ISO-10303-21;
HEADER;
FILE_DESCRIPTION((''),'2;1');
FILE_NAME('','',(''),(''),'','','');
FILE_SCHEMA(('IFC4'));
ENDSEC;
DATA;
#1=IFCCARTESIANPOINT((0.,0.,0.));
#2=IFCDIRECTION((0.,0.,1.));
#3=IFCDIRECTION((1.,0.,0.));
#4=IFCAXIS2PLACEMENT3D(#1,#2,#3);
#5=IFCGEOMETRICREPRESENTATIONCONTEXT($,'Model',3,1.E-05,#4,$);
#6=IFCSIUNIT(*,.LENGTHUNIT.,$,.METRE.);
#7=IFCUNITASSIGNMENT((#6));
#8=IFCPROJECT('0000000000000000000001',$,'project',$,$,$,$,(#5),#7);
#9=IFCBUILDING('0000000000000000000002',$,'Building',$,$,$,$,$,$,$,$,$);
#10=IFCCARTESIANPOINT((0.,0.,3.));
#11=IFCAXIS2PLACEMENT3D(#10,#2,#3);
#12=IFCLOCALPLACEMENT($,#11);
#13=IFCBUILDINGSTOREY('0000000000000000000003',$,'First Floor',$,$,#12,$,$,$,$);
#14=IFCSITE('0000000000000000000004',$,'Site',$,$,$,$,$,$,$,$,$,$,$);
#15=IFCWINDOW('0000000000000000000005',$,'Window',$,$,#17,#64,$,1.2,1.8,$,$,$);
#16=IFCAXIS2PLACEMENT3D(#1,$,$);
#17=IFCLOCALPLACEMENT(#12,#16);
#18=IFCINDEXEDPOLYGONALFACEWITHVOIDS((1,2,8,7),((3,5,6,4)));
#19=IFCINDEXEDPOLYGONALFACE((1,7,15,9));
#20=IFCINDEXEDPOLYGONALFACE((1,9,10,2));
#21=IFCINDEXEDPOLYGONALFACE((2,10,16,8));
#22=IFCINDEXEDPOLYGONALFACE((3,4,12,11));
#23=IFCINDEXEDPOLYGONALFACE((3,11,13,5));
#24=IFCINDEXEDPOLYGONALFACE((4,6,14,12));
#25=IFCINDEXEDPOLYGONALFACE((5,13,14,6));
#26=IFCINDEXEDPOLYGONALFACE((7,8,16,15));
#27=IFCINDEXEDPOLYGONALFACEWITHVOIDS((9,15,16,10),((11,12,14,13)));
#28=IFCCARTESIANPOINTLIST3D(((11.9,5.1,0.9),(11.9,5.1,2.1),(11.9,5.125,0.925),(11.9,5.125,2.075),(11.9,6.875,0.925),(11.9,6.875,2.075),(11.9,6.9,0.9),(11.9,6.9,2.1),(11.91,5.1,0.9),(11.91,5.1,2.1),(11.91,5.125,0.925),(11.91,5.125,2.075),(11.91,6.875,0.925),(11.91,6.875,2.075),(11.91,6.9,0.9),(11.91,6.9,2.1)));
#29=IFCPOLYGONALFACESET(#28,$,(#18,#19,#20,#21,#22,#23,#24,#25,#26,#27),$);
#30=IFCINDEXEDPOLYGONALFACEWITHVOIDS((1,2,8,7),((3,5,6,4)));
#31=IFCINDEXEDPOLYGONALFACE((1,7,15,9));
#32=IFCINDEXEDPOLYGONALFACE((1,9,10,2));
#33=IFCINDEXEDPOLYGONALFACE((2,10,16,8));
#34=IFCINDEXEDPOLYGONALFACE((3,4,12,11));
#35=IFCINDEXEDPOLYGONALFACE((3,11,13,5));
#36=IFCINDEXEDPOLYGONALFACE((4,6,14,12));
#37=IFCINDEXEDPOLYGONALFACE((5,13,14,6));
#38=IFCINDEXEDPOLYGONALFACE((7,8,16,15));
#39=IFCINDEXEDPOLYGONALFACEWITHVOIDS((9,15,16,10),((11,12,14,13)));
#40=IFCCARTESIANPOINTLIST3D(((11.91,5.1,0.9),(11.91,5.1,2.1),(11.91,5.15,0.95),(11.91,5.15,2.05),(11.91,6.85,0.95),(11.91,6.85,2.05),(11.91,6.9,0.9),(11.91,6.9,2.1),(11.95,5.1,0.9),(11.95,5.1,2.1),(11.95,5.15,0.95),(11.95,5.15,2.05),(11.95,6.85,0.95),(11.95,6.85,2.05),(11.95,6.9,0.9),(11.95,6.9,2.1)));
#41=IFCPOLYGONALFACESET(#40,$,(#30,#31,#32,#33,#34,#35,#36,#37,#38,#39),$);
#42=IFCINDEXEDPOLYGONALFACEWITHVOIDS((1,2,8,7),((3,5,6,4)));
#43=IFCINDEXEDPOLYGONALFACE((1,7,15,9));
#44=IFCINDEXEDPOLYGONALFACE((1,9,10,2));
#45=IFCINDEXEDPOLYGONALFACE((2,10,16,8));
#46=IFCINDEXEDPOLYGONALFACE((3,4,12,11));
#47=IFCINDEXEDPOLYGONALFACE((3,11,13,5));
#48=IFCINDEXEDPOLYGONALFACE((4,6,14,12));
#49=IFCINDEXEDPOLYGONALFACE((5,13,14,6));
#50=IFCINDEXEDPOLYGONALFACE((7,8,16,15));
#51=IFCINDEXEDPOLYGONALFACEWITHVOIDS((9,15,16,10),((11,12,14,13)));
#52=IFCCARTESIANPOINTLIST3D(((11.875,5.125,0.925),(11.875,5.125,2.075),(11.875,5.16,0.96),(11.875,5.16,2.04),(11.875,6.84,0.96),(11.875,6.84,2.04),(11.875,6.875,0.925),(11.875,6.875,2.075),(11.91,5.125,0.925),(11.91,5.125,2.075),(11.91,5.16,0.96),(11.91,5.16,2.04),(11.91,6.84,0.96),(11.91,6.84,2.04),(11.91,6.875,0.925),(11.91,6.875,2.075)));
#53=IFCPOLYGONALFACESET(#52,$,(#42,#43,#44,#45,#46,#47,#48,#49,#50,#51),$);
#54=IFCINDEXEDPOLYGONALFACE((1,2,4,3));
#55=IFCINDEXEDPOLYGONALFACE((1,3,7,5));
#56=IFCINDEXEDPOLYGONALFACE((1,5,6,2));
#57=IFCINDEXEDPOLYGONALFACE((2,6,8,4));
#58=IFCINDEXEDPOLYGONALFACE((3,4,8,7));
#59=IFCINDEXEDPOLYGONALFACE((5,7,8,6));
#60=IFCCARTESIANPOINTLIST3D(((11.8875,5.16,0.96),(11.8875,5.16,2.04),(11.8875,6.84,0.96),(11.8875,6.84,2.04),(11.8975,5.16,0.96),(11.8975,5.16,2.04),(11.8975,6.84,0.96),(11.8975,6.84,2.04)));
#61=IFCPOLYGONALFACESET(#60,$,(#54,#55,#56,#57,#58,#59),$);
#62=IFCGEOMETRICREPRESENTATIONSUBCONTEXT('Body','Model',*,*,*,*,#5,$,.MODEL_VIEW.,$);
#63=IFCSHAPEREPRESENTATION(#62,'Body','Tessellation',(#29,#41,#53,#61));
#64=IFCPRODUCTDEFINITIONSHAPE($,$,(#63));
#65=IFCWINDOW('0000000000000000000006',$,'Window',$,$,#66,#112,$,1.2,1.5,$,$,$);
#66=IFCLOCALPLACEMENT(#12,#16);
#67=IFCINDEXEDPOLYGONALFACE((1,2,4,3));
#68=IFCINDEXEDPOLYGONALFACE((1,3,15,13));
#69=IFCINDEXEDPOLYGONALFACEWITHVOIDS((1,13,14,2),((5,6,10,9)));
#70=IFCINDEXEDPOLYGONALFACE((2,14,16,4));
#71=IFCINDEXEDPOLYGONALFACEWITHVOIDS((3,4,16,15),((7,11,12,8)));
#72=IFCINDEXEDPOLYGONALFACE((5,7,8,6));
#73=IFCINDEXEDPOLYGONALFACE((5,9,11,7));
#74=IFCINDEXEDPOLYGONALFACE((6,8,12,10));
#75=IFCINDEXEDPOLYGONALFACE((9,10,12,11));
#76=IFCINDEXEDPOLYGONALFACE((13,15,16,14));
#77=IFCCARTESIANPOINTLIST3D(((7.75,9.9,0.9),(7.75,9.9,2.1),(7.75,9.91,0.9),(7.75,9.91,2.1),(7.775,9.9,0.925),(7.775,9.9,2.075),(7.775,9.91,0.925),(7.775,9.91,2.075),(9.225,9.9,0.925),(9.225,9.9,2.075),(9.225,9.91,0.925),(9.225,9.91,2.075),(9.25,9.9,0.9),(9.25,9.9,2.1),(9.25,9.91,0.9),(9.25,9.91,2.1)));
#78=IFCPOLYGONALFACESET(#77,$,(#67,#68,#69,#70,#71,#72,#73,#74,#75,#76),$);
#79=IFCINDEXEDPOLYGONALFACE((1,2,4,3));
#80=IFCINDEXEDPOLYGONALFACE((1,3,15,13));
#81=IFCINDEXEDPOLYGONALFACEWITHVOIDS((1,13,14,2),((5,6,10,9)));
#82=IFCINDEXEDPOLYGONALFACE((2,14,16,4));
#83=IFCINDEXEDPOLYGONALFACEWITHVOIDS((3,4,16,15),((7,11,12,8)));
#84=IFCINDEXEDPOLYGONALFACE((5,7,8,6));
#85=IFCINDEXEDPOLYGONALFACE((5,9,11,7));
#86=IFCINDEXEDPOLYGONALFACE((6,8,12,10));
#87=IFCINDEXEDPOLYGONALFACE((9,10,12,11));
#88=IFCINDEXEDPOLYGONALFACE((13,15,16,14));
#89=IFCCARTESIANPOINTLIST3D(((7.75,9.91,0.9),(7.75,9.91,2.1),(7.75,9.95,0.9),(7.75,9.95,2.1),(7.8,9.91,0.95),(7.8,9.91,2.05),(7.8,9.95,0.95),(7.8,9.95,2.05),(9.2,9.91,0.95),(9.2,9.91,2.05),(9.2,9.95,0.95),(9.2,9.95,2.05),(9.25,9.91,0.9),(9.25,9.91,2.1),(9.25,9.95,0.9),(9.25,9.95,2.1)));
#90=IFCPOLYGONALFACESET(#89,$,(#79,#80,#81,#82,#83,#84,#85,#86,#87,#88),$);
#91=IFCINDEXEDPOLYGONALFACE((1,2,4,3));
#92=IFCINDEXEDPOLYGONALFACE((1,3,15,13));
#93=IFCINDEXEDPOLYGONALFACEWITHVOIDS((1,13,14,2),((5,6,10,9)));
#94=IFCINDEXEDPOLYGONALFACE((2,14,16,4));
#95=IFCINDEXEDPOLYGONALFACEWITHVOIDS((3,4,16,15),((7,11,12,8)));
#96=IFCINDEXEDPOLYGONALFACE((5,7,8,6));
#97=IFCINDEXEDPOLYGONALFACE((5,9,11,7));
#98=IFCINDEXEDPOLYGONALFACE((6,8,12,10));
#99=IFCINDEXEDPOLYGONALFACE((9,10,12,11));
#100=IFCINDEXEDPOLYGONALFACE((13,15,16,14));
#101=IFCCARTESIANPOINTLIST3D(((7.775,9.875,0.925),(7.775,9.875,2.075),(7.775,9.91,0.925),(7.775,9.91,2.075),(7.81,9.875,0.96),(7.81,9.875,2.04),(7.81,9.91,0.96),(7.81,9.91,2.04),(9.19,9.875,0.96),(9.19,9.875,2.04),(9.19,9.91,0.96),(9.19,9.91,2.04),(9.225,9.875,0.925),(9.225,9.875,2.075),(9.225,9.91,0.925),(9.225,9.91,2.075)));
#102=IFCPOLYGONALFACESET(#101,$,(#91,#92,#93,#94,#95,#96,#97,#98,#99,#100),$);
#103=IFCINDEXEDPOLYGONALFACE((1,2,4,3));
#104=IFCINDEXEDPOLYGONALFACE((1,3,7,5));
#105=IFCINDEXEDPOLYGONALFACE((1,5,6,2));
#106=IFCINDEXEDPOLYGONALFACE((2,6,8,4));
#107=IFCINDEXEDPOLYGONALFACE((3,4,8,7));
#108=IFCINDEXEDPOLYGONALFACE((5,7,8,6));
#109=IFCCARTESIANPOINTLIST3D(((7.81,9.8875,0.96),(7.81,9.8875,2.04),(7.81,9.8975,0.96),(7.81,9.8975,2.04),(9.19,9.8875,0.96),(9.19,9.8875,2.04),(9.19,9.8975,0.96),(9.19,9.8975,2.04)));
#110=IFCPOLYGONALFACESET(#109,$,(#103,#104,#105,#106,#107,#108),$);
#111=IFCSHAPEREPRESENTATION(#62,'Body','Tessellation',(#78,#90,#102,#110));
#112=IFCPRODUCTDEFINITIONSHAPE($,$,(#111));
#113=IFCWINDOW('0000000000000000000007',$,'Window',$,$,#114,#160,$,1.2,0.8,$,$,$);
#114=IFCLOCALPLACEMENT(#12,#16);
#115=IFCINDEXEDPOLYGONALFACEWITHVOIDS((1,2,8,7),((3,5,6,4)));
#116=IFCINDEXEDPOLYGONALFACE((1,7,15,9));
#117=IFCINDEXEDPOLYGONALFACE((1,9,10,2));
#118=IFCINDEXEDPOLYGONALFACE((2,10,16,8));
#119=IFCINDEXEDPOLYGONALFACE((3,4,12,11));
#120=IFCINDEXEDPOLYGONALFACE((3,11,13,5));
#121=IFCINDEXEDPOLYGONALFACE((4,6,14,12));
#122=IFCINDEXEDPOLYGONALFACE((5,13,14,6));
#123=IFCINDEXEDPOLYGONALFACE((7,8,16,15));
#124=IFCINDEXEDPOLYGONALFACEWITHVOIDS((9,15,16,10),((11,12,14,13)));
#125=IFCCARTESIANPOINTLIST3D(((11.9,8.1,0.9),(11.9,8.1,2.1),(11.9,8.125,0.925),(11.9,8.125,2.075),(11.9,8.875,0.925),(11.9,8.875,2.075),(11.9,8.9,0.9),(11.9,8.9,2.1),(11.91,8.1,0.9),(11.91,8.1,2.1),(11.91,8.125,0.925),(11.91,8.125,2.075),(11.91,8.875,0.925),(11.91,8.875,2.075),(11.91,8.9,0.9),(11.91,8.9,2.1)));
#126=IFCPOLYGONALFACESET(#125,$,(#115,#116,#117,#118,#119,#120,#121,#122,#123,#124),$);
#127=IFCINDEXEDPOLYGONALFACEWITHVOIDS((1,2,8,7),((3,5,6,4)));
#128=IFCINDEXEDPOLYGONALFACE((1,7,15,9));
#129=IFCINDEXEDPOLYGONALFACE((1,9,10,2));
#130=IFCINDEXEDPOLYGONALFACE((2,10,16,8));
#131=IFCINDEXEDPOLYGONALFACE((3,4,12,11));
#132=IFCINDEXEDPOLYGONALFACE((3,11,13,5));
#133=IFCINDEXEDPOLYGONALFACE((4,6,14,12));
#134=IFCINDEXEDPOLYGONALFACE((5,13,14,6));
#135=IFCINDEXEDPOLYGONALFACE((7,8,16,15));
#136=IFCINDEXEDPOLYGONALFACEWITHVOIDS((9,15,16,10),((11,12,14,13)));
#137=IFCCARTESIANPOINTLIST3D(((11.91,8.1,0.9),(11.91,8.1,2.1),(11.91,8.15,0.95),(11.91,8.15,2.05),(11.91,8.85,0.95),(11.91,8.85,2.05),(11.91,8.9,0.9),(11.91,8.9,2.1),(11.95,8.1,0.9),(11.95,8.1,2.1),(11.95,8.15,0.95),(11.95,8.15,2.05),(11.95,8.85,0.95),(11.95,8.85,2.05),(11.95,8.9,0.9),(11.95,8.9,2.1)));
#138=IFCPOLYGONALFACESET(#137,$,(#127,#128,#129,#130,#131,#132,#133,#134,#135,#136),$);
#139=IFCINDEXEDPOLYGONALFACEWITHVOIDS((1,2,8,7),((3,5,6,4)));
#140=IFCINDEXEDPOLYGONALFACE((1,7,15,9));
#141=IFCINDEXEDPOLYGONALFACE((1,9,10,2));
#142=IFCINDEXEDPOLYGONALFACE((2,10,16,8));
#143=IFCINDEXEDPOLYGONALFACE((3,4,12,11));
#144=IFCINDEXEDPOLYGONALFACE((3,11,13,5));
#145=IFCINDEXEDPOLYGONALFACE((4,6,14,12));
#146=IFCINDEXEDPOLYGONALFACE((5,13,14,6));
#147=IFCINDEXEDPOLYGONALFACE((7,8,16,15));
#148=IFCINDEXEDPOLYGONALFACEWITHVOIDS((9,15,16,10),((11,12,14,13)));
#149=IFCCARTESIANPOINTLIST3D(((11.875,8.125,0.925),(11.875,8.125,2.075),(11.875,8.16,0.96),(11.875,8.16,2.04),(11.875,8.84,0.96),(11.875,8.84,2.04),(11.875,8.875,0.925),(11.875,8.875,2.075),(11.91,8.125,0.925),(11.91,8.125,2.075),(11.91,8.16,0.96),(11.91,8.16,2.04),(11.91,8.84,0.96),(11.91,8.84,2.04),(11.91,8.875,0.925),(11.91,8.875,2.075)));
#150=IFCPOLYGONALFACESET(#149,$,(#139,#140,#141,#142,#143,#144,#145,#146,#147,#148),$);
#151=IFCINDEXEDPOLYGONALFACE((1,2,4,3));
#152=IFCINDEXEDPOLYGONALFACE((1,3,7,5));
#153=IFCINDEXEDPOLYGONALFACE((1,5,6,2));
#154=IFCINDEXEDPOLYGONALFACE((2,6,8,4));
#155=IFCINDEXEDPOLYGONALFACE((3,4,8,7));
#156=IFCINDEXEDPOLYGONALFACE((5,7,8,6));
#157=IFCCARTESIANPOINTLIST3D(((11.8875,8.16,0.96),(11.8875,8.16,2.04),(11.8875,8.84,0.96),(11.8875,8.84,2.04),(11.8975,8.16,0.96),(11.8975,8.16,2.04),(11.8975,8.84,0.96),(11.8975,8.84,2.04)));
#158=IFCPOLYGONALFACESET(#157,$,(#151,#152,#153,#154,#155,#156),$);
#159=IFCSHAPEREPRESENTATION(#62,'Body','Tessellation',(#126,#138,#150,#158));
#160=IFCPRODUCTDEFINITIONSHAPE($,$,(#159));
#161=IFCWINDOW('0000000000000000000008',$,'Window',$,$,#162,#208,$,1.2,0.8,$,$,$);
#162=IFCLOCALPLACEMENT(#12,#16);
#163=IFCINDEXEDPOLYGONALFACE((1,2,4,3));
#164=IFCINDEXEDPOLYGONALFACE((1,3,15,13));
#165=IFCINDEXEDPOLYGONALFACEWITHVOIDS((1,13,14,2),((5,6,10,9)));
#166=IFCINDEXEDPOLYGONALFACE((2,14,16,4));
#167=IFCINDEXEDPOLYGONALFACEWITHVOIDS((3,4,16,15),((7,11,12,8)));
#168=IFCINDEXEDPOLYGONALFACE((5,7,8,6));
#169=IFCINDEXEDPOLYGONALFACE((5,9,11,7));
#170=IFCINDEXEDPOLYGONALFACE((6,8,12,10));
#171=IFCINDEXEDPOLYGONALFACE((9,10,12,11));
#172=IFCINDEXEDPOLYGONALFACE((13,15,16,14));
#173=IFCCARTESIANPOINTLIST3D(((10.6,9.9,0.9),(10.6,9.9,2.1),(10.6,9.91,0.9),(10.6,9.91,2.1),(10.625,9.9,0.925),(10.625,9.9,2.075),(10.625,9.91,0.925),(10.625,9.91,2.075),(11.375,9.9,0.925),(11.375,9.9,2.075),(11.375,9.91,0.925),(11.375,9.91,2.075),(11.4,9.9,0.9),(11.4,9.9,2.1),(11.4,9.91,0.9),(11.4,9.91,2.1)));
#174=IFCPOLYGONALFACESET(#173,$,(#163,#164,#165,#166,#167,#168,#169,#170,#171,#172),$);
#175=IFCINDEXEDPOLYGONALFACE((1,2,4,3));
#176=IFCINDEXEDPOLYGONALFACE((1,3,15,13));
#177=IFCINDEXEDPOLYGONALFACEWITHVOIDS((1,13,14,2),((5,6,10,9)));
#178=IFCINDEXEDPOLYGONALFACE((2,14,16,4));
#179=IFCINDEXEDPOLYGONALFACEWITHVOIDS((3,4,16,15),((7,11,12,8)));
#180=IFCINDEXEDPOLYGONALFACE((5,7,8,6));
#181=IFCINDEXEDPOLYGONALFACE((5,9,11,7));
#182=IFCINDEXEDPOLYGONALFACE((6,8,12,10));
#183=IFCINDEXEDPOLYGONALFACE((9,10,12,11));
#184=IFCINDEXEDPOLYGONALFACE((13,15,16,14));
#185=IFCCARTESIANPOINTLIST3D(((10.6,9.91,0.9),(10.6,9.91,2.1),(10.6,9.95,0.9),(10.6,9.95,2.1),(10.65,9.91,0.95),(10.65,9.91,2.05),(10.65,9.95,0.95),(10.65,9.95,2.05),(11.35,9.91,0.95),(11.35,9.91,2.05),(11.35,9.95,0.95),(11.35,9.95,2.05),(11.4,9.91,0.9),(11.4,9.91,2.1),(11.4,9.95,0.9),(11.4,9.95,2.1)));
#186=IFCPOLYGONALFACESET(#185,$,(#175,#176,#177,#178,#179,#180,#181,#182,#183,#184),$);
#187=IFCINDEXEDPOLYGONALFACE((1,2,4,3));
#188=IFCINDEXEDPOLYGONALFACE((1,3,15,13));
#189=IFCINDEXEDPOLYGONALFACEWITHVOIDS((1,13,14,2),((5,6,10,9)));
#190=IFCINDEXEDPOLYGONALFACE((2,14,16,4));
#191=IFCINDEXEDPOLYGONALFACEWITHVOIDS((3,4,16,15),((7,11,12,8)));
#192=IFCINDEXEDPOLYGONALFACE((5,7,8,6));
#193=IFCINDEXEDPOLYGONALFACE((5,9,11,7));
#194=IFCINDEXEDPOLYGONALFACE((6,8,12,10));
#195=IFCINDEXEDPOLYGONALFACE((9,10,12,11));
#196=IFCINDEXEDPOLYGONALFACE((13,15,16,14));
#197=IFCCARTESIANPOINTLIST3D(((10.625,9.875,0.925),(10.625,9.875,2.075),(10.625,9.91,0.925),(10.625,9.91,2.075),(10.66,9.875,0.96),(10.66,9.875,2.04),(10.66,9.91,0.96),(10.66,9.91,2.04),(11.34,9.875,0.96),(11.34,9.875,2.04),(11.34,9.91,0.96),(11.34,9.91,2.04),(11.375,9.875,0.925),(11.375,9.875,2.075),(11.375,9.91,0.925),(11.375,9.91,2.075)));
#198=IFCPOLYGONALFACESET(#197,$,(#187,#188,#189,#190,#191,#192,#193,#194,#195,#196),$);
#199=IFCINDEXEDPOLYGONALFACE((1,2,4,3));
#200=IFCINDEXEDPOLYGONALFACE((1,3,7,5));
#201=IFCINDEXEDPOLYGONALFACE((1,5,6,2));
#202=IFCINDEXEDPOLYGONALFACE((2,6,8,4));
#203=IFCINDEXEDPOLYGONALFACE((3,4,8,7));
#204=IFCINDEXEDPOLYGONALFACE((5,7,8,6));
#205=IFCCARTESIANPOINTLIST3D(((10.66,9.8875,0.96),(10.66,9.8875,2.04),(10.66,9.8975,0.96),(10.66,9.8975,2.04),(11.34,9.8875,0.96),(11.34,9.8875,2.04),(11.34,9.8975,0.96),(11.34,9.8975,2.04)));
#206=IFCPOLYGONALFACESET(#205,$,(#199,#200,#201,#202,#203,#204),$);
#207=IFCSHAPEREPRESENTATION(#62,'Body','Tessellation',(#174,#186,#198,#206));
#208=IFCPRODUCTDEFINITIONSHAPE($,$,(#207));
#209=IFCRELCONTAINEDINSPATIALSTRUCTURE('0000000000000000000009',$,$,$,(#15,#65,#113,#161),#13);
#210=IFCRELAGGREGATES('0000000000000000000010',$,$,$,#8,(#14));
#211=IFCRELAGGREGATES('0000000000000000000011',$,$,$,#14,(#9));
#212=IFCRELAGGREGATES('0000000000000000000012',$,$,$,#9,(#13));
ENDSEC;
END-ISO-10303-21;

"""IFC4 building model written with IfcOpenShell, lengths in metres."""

from ifc_helpers import new_model, si_unit, frame, origin_with_axes, place, context, subcontext, project, spatial, line, indexed_curve, outline, extrude, element, save


model = new_model("IFC4")

# Units and contexts
model_context = context("Model", 3, precision=1e-05, world=origin_with_axes())
body_context = subcontext(model_context, "Body", "Model", "MODEL_VIEW")
ifc_project = project(units=[si_unit("LENGTHUNIT", "METRE")], contexts=[model_context])

# Site, building, storey
site = spatial("IfcSite", under=ifc_project, Name="Site")
building = spatial("IfcBuilding", under=site, Name="Building")
storey_placement = place(None, frame((0.0, 0.0, 3.0), z_axis=(0.0, 0.0, 1.0), x_axis=(1.0, 0.0, 0.0)))
storey = spatial("IfcBuildingStorey", under=building, at=storey_placement, Name="First Floor")

# Windows
window_1_placement = place(storey_placement, frame((12.0, 5.1, 0.9), z_axis=(0.0, 0.0, 1.0), x_axis=(0.0, 1.0, 0.0)))
element("IfcWindow", 1, at=window_1_placement, inside=storey, Name="Window", OverallHeight=1.2, OverallWidth=1.8, context=body_context, shape_type="SweptSolid", body=[
    extrude(outline(indexed_curve([(0.0, 0.0), (1.8, 0.0), (1.8, 1.2), (0.0, 1.2)], segments=[line(1, 2, 3, 4, 1)]), holes=[indexed_curve([(0.025, 0.025), (1.775, 0.025), (1.775, 1.175), (0.025, 1.175)], segments=[line(1, 2, 3, 4, 1)])]), frame((0.0, 0.09, 0.0), z_axis=(0.0, -1.0, 0.0), x_axis=(1.0, 0.0, 0.0)), (0.0, 0.0, -1.0), 0.01),
    extrude(outline(indexed_curve([(0.0, 0.0), (1.8, 0.0), (1.8, 1.2), (0.0, 1.2)], segments=[line(1, 2, 3, 4, 1)]), holes=[indexed_curve([(0.05, 0.05), (1.75, 0.05), (1.75, 1.15), (0.05, 1.15)], segments=[line(1, 2, 3, 4, 1)])]), frame((0.0, 0.05, 0.0), z_axis=(0.0, -1.0, 0.0), x_axis=(1.0, 0.0, 0.0)), (0.0, 0.0, -1.0), 0.04),
    extrude(outline(indexed_curve([(0.0, 0.0), (1.75, 0.0), (1.75, 1.15), (0.0, 1.15)], segments=[line(1, 2, 3, 4, 1)]), holes=[indexed_curve([(0.035, 0.035), (1.715, 0.035), (1.715, 1.115), (0.035, 1.115)], segments=[line(1, 2, 3, 4, 1)])]), frame((0.025, 0.09, 0.025), z_axis=(0.0, -1.0, 0.0), x_axis=(1.0, 0.0, 0.0)), (0.0, 0.0, -1.0), 0.035),
    extrude(outline(indexed_curve([(0.035, 0.035), (1.715, 0.035), (1.715, 1.115), (0.035, 1.115)], segments=[line(1, 2, 3, 4, 1)])), frame((0.025, 0.1025, 0.025), z_axis=(0.0, -1.0, 0.0), x_axis=(1.0, 0.0, 0.0)), (0.0, 0.0, -1.0), 0.01),
])
window_2_placement = place(storey_placement, frame((9.25, 10.0, 0.9), z_axis=(0.0, 0.0, 1.0), x_axis=(-1.0, 0.0, 0.0)))
element("IfcWindow", 2, at=window_2_placement, inside=storey, Name="Window", OverallHeight=1.2, OverallWidth=1.5, context=body_context, shape_type="SweptSolid", body=[
    extrude(outline(indexed_curve([(0.0, 0.0), (1.5, 0.0), (1.5, 1.2), (0.0, 1.2)], segments=[line(1, 2, 3, 4, 1)]), holes=[indexed_curve([(0.025, 0.025), (1.475, 0.025), (1.475, 1.175), (0.025, 1.175)], segments=[line(1, 2, 3, 4, 1)])]), frame((0.0, 0.09, 0.0), z_axis=(0.0, -1.0, 0.0), x_axis=(1.0, 0.0, 0.0)), (0.0, 0.0, -1.0), 0.01),
    extrude(outline(indexed_curve([(0.0, 0.0), (1.5, 0.0), (1.5, 1.2), (0.0, 1.2)], segments=[line(1, 2, 3, 4, 1)]), holes=[indexed_curve([(0.05, 0.05), (1.45, 0.05), (1.45, 1.15), (0.05, 1.15)], segments=[line(1, 2, 3, 4, 1)])]), frame((0.0, 0.05, 0.0), z_axis=(0.0, -1.0, 0.0), x_axis=(1.0, 0.0, 0.0)), (0.0, 0.0, -1.0), 0.04),
    extrude(outline(indexed_curve([(0.0, 0.0), (1.45, 0.0), (1.45, 1.15), (0.0, 1.15)], segments=[line(1, 2, 3, 4, 1)]), holes=[indexed_curve([(0.035, 0.035), (1.415, 0.035), (1.415, 1.115), (0.035, 1.115)], segments=[line(1, 2, 3, 4, 1)])]), frame((0.025, 0.09, 0.025), z_axis=(0.0, -1.0, 0.0), x_axis=(1.0, 0.0, 0.0)), (0.0, 0.0, -1.0), 0.035),
    extrude(outline(indexed_curve([(0.035, 0.035), (1.415, 0.035), (1.415, 1.115), (0.035, 1.115)], segments=[line(1, 2, 3, 4, 1)])), frame((0.025, 0.1025, 0.025), z_axis=(0.0, -1.0, 0.0), x_axis=(1.0, 0.0, 0.0)), (0.0, 0.0, -1.0), 0.01),
])
for number, where, z_axis, x_axis, name in (
    (3, (12.0, 8.1, 0.9), (0.0, 0.0, 1.0), (0.0, 1.0, 0.0), "Window"),
    (4, (11.4, 10.0, 0.9), (0.0, 0.0, 1.0), (-1.0, 0.0, 0.0), "Window"),
):
    element("IfcWindow", number, at=place(storey_placement, frame(where, z_axis=z_axis, x_axis=x_axis)), inside=storey, Name=name, OverallHeight=1.2, OverallWidth=0.8, context=body_context, shape_type="SweptSolid", body=[
        extrude(outline(indexed_curve([(0.0, 0.0), (0.8, 0.0), (0.8, 1.2), (0.0, 1.2)], segments=[line(1, 2, 3, 4, 1)]), holes=[indexed_curve([(0.025, 0.025), (0.775, 0.025), (0.775, 1.175), (0.025, 1.175)], segments=[line(1, 2, 3, 4, 1)])]), frame((0.0, 0.09, 0.0), z_axis=(0.0, -1.0, 0.0), x_axis=(1.0, 0.0, 0.0)), (0.0, 0.0, -1.0), 0.01),
        extrude(outline(indexed_curve([(0.0, 0.0), (0.8, 0.0), (0.8, 1.2), (0.0, 1.2)], segments=[line(1, 2, 3, 4, 1)]), holes=[indexed_curve([(0.05, 0.05), (0.75, 0.05), (0.75, 1.15), (0.05, 1.15)], segments=[line(1, 2, 3, 4, 1)])]), frame((0.0, 0.05, 0.0), z_axis=(0.0, -1.0, 0.0), x_axis=(1.0, 0.0, 0.0)), (0.0, 0.0, -1.0), 0.04),
        extrude(outline(indexed_curve([(0.0, 0.0), (0.75, 0.0), (0.75, 1.15), (0.0, 1.15)], segments=[line(1, 2, 3, 4, 1)]), holes=[indexed_curve([(0.035, 0.035), (0.715, 0.035), (0.715, 1.115), (0.035, 1.115)], segments=[line(1, 2, 3, 4, 1)])]), frame((0.025, 0.09, 0.025), z_axis=(0.0, -1.0, 0.0), x_axis=(1.0, 0.0, 0.0)), (0.0, 0.0, -1.0), 0.035),
        extrude(outline(indexed_curve([(0.035, 0.035), (0.715, 0.035), (0.715, 1.115), (0.035, 1.115)], segments=[line(1, 2, 3, 4, 1)])), frame((0.025, 0.1025, 0.025), z_axis=(0.0, -1.0, 0.0), x_axis=(1.0, 0.0, 0.0)), (0.0, 0.0, -1.0), 0.01),
    ])

save(model, "model.ifc")
